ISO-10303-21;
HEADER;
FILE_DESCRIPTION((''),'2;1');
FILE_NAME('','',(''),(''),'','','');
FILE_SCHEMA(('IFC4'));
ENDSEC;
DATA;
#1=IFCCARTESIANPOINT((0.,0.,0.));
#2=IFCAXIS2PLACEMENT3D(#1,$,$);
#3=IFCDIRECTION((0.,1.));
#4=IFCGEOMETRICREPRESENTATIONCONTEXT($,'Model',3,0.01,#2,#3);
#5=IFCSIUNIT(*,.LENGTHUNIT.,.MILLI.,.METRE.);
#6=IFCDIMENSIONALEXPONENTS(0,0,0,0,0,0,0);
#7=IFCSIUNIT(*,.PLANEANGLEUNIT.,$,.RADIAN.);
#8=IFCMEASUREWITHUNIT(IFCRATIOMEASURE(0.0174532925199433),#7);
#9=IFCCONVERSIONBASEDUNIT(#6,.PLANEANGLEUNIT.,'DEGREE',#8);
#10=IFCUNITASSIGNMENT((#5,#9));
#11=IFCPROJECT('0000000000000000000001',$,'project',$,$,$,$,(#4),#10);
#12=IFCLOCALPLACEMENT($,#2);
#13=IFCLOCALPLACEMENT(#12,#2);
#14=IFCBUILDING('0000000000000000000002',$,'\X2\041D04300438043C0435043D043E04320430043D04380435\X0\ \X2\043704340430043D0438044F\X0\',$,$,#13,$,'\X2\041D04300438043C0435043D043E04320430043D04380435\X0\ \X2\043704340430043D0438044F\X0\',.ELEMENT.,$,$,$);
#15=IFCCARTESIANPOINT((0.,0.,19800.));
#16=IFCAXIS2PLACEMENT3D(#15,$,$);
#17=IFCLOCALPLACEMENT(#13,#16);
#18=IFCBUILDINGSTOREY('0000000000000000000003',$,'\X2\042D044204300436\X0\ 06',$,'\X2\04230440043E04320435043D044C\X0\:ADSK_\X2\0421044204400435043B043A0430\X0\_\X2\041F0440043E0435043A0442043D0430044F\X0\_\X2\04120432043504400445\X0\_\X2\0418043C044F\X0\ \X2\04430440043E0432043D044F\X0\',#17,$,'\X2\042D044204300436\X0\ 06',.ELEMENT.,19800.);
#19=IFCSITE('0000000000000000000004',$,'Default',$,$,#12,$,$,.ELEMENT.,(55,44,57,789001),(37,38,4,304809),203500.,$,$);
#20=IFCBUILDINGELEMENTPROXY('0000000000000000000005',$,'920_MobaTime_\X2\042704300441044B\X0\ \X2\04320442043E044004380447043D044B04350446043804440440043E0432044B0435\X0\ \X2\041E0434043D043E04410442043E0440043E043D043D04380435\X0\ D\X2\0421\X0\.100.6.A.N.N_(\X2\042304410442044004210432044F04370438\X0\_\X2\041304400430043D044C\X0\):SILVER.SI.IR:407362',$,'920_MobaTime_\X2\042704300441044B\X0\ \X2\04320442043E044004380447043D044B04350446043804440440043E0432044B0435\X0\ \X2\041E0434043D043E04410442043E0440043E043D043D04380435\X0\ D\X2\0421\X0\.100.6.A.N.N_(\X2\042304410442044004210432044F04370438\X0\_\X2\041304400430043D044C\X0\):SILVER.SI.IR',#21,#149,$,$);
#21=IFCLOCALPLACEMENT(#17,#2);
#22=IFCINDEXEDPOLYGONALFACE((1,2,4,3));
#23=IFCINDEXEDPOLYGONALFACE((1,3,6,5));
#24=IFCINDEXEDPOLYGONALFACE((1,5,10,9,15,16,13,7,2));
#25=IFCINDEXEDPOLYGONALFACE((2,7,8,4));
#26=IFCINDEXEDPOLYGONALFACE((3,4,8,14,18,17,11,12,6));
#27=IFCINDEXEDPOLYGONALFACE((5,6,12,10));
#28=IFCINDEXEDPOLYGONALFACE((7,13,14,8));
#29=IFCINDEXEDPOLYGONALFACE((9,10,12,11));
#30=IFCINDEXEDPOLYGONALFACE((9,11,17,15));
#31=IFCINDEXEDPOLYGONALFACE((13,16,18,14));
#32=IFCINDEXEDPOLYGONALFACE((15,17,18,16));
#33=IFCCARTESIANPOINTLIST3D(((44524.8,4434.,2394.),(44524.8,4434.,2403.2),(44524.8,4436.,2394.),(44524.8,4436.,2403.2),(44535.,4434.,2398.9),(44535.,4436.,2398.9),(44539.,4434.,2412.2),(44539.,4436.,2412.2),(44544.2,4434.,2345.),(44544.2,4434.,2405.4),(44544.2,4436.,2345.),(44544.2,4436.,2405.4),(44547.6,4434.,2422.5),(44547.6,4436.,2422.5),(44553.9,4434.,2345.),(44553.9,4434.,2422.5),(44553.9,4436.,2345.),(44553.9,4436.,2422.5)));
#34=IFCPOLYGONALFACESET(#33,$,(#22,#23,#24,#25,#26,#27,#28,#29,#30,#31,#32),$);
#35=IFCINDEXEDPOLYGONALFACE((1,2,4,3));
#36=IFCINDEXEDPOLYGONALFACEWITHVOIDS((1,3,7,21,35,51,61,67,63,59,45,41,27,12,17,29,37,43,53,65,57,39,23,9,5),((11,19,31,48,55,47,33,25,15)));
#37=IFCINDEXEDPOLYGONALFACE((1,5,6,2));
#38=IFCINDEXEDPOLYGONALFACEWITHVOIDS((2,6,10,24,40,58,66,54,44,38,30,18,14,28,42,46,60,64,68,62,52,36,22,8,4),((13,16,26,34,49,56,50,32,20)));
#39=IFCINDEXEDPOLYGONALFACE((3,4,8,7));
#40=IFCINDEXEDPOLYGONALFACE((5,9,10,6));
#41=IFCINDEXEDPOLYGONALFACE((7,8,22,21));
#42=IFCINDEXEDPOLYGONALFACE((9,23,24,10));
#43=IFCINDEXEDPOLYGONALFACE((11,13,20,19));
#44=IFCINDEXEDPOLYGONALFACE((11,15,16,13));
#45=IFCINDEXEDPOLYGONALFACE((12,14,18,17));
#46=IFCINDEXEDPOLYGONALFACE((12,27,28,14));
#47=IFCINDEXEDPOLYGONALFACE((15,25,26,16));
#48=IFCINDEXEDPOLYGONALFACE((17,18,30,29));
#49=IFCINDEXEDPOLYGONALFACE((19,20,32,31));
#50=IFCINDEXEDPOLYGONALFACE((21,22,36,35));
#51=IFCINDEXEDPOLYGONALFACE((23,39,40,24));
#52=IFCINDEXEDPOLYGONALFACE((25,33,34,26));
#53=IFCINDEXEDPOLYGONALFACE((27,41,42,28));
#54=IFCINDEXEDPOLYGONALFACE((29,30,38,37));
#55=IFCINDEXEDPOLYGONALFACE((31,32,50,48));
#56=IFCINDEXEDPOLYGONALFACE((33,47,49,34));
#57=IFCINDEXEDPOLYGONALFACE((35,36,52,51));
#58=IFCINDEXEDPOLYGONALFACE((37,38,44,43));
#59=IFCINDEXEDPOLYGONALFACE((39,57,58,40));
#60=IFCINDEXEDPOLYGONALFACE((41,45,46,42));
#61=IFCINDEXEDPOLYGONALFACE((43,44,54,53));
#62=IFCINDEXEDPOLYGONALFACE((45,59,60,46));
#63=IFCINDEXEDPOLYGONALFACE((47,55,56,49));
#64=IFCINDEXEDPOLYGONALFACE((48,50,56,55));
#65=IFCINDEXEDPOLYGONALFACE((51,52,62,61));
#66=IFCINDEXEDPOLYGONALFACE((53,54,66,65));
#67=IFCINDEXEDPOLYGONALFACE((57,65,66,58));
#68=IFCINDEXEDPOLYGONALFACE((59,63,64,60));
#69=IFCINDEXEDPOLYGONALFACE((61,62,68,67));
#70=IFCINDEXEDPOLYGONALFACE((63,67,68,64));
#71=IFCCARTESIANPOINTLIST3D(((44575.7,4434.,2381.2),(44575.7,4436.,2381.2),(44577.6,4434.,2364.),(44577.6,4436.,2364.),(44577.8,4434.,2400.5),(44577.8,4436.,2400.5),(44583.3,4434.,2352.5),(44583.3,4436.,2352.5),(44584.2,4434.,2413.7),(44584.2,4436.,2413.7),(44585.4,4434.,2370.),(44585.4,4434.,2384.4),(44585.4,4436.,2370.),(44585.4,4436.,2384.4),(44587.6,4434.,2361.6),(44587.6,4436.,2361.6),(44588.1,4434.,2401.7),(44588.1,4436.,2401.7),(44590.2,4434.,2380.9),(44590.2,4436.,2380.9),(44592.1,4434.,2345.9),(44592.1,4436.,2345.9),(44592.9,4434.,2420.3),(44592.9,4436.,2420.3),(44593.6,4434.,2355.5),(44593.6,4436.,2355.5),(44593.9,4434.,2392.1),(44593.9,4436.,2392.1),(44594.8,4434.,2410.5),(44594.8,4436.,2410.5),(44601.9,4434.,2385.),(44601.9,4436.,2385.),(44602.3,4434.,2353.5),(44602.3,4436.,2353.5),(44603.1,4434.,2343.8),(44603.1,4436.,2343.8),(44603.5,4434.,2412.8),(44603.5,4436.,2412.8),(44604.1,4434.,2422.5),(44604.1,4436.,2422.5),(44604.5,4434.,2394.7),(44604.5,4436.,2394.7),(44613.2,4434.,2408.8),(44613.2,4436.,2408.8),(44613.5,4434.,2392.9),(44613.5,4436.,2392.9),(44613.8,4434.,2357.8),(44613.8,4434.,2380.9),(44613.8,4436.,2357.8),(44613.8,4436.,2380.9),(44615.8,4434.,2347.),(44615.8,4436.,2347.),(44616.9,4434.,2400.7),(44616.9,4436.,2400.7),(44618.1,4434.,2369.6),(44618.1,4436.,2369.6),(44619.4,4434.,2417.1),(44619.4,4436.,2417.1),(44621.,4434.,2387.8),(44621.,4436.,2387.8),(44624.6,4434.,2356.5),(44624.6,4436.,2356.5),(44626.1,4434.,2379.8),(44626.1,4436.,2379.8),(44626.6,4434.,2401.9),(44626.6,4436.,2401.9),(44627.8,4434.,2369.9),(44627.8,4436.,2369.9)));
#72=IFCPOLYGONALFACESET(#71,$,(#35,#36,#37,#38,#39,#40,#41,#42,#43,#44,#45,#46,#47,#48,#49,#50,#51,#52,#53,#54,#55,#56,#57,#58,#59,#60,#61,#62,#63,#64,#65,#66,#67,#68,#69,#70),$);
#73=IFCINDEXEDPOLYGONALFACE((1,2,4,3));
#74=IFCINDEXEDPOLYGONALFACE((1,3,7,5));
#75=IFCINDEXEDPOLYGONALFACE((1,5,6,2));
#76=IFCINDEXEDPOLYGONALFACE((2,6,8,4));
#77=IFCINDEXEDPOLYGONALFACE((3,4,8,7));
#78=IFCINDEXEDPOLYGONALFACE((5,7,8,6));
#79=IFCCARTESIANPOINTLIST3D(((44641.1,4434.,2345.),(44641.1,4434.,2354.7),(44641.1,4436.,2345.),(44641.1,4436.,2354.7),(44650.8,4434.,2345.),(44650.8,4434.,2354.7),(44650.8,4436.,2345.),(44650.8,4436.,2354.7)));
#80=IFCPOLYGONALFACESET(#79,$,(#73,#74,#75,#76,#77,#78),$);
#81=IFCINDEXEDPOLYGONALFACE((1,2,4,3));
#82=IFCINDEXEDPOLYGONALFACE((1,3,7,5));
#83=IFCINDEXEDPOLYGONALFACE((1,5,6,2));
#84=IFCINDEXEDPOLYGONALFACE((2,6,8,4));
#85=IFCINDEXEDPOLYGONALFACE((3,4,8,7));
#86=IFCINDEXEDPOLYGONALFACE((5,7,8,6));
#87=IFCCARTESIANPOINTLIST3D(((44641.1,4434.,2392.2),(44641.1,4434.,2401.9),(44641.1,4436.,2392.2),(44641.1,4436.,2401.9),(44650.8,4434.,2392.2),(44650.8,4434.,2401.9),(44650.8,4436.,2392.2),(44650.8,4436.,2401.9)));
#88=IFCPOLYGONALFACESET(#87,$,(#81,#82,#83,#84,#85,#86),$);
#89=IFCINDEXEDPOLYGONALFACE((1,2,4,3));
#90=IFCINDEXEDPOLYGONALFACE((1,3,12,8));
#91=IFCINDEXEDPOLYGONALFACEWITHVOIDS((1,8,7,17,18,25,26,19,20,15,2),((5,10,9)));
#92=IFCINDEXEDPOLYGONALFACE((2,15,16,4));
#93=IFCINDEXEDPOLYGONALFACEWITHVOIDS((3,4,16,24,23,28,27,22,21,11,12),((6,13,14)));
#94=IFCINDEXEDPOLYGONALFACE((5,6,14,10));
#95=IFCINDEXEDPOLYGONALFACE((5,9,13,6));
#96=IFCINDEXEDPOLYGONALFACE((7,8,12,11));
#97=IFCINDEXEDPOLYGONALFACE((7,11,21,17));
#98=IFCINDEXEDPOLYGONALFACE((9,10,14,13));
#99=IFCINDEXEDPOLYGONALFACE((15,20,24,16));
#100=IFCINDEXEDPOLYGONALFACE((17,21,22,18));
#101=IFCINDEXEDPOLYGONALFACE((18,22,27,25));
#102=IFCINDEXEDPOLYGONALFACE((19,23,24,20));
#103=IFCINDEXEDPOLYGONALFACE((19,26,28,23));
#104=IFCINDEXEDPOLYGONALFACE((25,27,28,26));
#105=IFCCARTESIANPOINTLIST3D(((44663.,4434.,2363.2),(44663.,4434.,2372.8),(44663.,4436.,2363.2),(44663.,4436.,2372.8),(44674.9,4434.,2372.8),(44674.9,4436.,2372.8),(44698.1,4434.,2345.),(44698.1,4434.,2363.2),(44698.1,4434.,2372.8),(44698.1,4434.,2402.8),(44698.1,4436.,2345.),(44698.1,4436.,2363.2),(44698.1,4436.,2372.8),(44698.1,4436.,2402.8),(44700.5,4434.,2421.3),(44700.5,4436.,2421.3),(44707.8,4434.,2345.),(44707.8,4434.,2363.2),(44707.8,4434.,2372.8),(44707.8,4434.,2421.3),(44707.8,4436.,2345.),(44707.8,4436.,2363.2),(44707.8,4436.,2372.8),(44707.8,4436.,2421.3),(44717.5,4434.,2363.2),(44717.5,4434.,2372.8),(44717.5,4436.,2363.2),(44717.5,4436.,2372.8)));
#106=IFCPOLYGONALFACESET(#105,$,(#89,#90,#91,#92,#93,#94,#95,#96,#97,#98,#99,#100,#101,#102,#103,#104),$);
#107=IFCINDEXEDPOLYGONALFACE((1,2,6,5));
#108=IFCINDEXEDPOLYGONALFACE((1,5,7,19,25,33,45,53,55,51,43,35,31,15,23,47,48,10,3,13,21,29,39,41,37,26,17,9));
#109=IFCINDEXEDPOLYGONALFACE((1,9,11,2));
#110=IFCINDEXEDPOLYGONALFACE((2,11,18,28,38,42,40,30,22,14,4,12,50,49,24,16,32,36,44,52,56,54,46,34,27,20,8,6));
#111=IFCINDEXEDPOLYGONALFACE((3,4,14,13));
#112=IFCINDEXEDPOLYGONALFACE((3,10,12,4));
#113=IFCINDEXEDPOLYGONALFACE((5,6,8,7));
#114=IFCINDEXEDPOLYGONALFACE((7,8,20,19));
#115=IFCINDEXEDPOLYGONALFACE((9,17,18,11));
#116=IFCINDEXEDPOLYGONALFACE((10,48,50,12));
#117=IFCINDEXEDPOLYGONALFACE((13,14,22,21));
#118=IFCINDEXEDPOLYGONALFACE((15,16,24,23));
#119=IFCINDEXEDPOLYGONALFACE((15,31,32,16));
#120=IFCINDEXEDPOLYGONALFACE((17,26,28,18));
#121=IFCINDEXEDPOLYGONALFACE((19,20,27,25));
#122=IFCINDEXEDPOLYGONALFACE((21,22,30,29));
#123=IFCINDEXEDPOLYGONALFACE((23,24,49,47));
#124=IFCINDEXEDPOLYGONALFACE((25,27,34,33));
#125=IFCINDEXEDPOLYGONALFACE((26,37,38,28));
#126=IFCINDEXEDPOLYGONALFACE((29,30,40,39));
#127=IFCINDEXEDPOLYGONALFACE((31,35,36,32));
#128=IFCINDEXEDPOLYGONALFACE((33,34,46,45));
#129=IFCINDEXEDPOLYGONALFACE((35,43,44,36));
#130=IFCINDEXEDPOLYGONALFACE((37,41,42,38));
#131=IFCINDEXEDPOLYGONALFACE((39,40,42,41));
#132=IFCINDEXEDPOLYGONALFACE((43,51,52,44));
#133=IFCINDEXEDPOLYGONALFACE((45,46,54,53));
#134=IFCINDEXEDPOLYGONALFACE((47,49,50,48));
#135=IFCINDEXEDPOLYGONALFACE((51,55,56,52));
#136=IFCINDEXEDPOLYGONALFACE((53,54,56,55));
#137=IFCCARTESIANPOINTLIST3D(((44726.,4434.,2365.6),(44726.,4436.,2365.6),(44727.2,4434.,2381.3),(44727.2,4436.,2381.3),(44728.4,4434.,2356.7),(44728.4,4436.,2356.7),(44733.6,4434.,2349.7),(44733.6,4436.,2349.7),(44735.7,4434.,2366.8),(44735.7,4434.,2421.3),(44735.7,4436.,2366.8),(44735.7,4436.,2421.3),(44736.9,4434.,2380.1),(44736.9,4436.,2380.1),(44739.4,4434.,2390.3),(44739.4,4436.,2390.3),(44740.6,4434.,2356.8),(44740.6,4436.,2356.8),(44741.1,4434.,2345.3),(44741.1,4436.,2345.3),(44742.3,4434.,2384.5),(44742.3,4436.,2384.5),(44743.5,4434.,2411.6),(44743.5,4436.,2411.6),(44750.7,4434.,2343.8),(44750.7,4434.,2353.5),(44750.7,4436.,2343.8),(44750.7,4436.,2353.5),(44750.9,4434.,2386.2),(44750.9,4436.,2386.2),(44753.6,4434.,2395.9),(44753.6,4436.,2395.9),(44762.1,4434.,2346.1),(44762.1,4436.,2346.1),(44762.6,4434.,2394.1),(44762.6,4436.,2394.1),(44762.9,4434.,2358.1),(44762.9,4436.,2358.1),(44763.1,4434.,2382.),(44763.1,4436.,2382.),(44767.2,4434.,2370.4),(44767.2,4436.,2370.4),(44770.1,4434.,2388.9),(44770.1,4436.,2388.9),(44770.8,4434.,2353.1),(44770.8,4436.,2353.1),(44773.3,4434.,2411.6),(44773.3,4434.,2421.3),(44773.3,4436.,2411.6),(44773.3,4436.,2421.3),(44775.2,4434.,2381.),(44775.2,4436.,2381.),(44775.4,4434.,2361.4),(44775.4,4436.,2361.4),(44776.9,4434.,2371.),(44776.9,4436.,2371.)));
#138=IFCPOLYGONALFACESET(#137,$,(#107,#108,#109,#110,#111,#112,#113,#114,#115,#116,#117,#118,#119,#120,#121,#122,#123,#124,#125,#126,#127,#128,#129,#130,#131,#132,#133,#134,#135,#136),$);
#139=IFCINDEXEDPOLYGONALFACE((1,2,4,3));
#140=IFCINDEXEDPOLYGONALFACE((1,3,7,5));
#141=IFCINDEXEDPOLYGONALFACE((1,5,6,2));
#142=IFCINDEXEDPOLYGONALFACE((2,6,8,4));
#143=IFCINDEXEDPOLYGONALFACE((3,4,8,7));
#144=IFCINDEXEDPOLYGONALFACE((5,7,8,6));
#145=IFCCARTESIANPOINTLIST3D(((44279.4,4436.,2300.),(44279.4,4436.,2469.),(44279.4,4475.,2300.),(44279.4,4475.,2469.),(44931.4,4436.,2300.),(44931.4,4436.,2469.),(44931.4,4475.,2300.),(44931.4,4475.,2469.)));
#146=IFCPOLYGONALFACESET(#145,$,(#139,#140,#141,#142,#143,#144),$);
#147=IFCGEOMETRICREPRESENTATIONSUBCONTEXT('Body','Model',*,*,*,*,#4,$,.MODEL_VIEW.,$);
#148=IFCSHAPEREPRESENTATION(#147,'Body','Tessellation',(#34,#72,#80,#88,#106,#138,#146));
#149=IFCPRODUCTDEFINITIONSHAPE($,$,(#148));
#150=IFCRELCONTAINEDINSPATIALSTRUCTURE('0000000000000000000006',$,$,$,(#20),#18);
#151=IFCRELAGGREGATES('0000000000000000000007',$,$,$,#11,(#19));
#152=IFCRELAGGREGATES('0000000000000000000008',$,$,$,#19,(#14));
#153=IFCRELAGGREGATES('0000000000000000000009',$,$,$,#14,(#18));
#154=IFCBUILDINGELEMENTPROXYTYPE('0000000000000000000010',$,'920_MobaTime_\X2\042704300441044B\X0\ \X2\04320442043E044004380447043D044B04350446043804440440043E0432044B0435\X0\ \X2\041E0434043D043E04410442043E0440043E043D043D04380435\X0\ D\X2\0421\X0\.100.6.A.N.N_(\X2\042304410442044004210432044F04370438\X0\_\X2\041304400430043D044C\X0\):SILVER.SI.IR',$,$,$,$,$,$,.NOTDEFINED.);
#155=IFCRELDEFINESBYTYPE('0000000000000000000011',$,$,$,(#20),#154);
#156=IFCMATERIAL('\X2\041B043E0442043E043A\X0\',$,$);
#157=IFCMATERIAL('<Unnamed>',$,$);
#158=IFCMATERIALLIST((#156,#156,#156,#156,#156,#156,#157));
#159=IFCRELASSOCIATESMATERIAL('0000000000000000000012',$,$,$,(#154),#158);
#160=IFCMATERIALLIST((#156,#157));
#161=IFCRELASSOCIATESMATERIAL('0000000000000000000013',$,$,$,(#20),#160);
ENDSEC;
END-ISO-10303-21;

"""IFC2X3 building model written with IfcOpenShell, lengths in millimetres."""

from ifc_helpers import new_model, entity, si_unit, converted_unit, direction, frame, origin, origin_2d_with_axis, place, context, subcontext, project, spatial, polyline, rectangle, outline, extrude, source, transform, mapped, material, material_list, type_object, type_shapes, element, save


model = new_model("IFC2X3")

# Units and contexts
model_context = context("Model", 3, precision=0.01, world=origin(), true_north=direction((0.0, 1.0)))
body_context = subcontext(model_context, "Body", "Model", "MODEL_VIEW")
ifc_project = project(units=[si_unit("LENGTHUNIT", "METRE", prefix="MILLI"), converted_unit("PLANEANGLEUNIT", "DEGREE", entity("IfcRatioMeasure", 0.0174532925199433), si_unit("PLANEANGLEUNIT", "RADIAN"), dimensions=[0, 0, 0, 0, 0, 0, 0])], contexts=[model_context])

# Site, building, storey
site_placement = place(None, frame((0.0, 0.0, 0.0)))
site = spatial("IfcSite", under=ifc_project, at=site_placement, Name="Default", CompositionType="ELEMENT", RefLatitude=(55, 44, 57, 789001), RefLongitude=(37, 38, 4, 304809), RefElevation=203500.0)
building_placement = place(site_placement, origin())
building = spatial("IfcBuilding", under=site, at=building_placement, Name="Наименование здания", LongName="Наименование здания", CompositionType="ELEMENT")
storey_placement = place(building_placement, frame((0.0, 0.0, 19800.0)))
storey = spatial("IfcBuildingStorey", under=building, at=storey_placement, Name="Этаж 06", ObjectType="Уровень:ADSK_Стрелка_Проектная_Вверх_Имя уровня", LongName="Этаж 06", CompositionType="ELEMENT", Elevation=19800.0)

# Building element proxy
ifc_material_1 = material(Name="Лоток")
ifc_material_2 = material(Name="<Unnamed>")
ifc_material_list_1 = material_list([ifc_material_1, ifc_material_1, ifc_material_1, ifc_material_1, ifc_material_1, ifc_material_1, ifc_material_2])
building_element_proxy_type_1 = type_object("IfcBuildingElementProxyType", Name="920_MobaTime_Часы вторичныецифровые Односторонние DС.100.6.A.N.N_(УстрСвязи_Грань):SILVER.SI.IR", PredefinedType="NOTDEFINED", material=ifc_material_list_1)
shared_shape_1 = source(origin(), body_context, "Body", "SweptSolid", [
    extrude(outline(polyline([(-49.3, -13.1), (28.2, -13.1), (28.2, -6.8), (17.9, 1.8), (8.9, 16.0), (-0.3, 16.0), (4.6, 5.8), (11.1, -3.4), (-49.3, -3.4), (-49.3, -13.1)])), frame((-64.6, 9.8, 39.0), z_axis=(0.0, 0.0, 1.0), x_axis=(0.0, 1.0, 0.0)), (0.0, 0.0, 1.0), 2.0),
    extrude(outline(polyline([(2.2, -27.6), (19.0, -27.6), (30.5, -16.1), (33.3, -4.9), (31.0, 5.8), (21.8, 17.2), (5.2, 27.3), (-11.1, 33.0), (-24.0, 32.7), (-33.6, 27.6), (-40.3, 18.6), (-42.8, 5.7), (-38.0, -6.3), (-27.2, -15.0), (-17.5, -17.7), (-8.2, -16.4), (-0.3, -11.9), (5.1, -4.5), (7.3, 6.2), (4.0, 17.2), (18.5, 7.3), (23.6, -2.4), (22.0, -11.4), (14.2, -18.4), (5.3, -18.3), (2.2, -27.6)]), holes=[polyline([(-9.0, 23.3), (-1.3, 14.4), (-2.6, 2.0), (-11.4, -7.0), (-23.4, -6.1), (-32.2, 2.9), (-31.2, 15.1), (-25.6, 22.1), (-17.5, 24.9), (-9.0, 23.3)])]), frame((-2.7, 3.6, 39.0), z_axis=(0.0, 0.0, 1.0), x_axis=(-0.427649, 0.903945, 0.0)), (0.0, 0.0, 1.0), 2.0),
    extrude(rectangle(XDim=9.7, YDim=9.7, at=origin_2d_with_axis()), frame((40.6, -34.7, 39.0)), (0.0, 0.0, 1.0), 2.0),
    extrude(rectangle(XDim=9.7, YDim=9.7, at=origin_2d_with_axis()), frame((40.6, 12.6, 39.0)), (0.0, 0.0, 1.0), 2.0),
    extrude(outline(polyline([(-0.9, -28.1), (8.8, -28.1), (8.8, -9.9), (18.5, -9.9), (18.5, -0.2), (8.8, -0.2), (8.8, 48.3), (1.5, 48.3), (-36.0, -0.2), (-36.0, -9.9), (-0.9, -9.9), (-0.9, -28.1)]), holes=[polyline([(-0.9, -0.2), (-24.1, -0.2), (-0.9, 29.7), (-0.9, -0.2)])]), frame((93.6, -11.4, 39.0)), (0.0, 0.0, 1.0), 2.0),
    extrude(outline(polyline([(3.3, -28.3), (12.5, -28.3), (20.5, -25.0), (26.8, -18.8), (30.7, -10.0), (31.4, 1.6), (26.9, 11.8), (20.1, 18.4), (11.1, 22.3), (1.0, 23.3), (-7.9, 20.4), (-14.9, 14.5), (-18.9, 6.2), (-17.1, -9.0), (-36.7, 0.5), (-29.1, 29.3), (-38.5, 31.7), (-48.1, -4.6), (-11.6, -23.0), (-8.0, -14.0), (-10.8, -7.6), (-10.2, 1.1), (-3.0, 11.8), (9.2, 12.8), (20.0, 5.4), (21.3, -7.5), (15.5, -16.4), (4.6, -18.6), (3.3, -28.3)])), frame((147.1, -8.5, 39.0), z_axis=(0.0, 0.0, 1.0), x_axis=(0.256974, -0.966418, 0.0)), (0.0, 0.0, 1.0), 2.0),
    extrude(rectangle(XDim=652.0, YDim=169.0, at=origin_2d_with_axis()), frame((0.0, 0.0, 0.0), z_axis=(0.0, 0.0, 1.0), x_axis=(-1.0, 0.0, 0.0)), (0.0, 0.0, 1.0), 39.0),
])
type_shapes(building_element_proxy_type_1, [shared_shape_1])
ifc_material_list_2 = material_list([ifc_material_1, ifc_material_2])
proxy_1_placement = place(storey_placement, frame((44605.4, 4475.0, 2384.5), z_axis=(0.0, -1.0, 0.0), x_axis=(1.0, 0.0, 0.0)))
element("IfcBuildingElementProxy", 1, at=proxy_1_placement, inside=storey, type_object=building_element_proxy_type_1, material=ifc_material_list_2, Name="920_MobaTime_Часы вторичныецифровые Односторонние DС.100.6.A.N.N_(УстрСвязи_Грань):SILVER.SI.IR:407362", ObjectType="920_MobaTime_Часы вторичныецифровые Односторонние DС.100.6.A.N.N_(УстрСвязи_Грань):SILVER.SI.IR", context=body_context, shape_type="MappedRepresentation", body=[
    mapped(shared_shape_1, transform((0.0, 0.0, 0.0), scale=1.0)),
])

save(model, "model.ifc")
